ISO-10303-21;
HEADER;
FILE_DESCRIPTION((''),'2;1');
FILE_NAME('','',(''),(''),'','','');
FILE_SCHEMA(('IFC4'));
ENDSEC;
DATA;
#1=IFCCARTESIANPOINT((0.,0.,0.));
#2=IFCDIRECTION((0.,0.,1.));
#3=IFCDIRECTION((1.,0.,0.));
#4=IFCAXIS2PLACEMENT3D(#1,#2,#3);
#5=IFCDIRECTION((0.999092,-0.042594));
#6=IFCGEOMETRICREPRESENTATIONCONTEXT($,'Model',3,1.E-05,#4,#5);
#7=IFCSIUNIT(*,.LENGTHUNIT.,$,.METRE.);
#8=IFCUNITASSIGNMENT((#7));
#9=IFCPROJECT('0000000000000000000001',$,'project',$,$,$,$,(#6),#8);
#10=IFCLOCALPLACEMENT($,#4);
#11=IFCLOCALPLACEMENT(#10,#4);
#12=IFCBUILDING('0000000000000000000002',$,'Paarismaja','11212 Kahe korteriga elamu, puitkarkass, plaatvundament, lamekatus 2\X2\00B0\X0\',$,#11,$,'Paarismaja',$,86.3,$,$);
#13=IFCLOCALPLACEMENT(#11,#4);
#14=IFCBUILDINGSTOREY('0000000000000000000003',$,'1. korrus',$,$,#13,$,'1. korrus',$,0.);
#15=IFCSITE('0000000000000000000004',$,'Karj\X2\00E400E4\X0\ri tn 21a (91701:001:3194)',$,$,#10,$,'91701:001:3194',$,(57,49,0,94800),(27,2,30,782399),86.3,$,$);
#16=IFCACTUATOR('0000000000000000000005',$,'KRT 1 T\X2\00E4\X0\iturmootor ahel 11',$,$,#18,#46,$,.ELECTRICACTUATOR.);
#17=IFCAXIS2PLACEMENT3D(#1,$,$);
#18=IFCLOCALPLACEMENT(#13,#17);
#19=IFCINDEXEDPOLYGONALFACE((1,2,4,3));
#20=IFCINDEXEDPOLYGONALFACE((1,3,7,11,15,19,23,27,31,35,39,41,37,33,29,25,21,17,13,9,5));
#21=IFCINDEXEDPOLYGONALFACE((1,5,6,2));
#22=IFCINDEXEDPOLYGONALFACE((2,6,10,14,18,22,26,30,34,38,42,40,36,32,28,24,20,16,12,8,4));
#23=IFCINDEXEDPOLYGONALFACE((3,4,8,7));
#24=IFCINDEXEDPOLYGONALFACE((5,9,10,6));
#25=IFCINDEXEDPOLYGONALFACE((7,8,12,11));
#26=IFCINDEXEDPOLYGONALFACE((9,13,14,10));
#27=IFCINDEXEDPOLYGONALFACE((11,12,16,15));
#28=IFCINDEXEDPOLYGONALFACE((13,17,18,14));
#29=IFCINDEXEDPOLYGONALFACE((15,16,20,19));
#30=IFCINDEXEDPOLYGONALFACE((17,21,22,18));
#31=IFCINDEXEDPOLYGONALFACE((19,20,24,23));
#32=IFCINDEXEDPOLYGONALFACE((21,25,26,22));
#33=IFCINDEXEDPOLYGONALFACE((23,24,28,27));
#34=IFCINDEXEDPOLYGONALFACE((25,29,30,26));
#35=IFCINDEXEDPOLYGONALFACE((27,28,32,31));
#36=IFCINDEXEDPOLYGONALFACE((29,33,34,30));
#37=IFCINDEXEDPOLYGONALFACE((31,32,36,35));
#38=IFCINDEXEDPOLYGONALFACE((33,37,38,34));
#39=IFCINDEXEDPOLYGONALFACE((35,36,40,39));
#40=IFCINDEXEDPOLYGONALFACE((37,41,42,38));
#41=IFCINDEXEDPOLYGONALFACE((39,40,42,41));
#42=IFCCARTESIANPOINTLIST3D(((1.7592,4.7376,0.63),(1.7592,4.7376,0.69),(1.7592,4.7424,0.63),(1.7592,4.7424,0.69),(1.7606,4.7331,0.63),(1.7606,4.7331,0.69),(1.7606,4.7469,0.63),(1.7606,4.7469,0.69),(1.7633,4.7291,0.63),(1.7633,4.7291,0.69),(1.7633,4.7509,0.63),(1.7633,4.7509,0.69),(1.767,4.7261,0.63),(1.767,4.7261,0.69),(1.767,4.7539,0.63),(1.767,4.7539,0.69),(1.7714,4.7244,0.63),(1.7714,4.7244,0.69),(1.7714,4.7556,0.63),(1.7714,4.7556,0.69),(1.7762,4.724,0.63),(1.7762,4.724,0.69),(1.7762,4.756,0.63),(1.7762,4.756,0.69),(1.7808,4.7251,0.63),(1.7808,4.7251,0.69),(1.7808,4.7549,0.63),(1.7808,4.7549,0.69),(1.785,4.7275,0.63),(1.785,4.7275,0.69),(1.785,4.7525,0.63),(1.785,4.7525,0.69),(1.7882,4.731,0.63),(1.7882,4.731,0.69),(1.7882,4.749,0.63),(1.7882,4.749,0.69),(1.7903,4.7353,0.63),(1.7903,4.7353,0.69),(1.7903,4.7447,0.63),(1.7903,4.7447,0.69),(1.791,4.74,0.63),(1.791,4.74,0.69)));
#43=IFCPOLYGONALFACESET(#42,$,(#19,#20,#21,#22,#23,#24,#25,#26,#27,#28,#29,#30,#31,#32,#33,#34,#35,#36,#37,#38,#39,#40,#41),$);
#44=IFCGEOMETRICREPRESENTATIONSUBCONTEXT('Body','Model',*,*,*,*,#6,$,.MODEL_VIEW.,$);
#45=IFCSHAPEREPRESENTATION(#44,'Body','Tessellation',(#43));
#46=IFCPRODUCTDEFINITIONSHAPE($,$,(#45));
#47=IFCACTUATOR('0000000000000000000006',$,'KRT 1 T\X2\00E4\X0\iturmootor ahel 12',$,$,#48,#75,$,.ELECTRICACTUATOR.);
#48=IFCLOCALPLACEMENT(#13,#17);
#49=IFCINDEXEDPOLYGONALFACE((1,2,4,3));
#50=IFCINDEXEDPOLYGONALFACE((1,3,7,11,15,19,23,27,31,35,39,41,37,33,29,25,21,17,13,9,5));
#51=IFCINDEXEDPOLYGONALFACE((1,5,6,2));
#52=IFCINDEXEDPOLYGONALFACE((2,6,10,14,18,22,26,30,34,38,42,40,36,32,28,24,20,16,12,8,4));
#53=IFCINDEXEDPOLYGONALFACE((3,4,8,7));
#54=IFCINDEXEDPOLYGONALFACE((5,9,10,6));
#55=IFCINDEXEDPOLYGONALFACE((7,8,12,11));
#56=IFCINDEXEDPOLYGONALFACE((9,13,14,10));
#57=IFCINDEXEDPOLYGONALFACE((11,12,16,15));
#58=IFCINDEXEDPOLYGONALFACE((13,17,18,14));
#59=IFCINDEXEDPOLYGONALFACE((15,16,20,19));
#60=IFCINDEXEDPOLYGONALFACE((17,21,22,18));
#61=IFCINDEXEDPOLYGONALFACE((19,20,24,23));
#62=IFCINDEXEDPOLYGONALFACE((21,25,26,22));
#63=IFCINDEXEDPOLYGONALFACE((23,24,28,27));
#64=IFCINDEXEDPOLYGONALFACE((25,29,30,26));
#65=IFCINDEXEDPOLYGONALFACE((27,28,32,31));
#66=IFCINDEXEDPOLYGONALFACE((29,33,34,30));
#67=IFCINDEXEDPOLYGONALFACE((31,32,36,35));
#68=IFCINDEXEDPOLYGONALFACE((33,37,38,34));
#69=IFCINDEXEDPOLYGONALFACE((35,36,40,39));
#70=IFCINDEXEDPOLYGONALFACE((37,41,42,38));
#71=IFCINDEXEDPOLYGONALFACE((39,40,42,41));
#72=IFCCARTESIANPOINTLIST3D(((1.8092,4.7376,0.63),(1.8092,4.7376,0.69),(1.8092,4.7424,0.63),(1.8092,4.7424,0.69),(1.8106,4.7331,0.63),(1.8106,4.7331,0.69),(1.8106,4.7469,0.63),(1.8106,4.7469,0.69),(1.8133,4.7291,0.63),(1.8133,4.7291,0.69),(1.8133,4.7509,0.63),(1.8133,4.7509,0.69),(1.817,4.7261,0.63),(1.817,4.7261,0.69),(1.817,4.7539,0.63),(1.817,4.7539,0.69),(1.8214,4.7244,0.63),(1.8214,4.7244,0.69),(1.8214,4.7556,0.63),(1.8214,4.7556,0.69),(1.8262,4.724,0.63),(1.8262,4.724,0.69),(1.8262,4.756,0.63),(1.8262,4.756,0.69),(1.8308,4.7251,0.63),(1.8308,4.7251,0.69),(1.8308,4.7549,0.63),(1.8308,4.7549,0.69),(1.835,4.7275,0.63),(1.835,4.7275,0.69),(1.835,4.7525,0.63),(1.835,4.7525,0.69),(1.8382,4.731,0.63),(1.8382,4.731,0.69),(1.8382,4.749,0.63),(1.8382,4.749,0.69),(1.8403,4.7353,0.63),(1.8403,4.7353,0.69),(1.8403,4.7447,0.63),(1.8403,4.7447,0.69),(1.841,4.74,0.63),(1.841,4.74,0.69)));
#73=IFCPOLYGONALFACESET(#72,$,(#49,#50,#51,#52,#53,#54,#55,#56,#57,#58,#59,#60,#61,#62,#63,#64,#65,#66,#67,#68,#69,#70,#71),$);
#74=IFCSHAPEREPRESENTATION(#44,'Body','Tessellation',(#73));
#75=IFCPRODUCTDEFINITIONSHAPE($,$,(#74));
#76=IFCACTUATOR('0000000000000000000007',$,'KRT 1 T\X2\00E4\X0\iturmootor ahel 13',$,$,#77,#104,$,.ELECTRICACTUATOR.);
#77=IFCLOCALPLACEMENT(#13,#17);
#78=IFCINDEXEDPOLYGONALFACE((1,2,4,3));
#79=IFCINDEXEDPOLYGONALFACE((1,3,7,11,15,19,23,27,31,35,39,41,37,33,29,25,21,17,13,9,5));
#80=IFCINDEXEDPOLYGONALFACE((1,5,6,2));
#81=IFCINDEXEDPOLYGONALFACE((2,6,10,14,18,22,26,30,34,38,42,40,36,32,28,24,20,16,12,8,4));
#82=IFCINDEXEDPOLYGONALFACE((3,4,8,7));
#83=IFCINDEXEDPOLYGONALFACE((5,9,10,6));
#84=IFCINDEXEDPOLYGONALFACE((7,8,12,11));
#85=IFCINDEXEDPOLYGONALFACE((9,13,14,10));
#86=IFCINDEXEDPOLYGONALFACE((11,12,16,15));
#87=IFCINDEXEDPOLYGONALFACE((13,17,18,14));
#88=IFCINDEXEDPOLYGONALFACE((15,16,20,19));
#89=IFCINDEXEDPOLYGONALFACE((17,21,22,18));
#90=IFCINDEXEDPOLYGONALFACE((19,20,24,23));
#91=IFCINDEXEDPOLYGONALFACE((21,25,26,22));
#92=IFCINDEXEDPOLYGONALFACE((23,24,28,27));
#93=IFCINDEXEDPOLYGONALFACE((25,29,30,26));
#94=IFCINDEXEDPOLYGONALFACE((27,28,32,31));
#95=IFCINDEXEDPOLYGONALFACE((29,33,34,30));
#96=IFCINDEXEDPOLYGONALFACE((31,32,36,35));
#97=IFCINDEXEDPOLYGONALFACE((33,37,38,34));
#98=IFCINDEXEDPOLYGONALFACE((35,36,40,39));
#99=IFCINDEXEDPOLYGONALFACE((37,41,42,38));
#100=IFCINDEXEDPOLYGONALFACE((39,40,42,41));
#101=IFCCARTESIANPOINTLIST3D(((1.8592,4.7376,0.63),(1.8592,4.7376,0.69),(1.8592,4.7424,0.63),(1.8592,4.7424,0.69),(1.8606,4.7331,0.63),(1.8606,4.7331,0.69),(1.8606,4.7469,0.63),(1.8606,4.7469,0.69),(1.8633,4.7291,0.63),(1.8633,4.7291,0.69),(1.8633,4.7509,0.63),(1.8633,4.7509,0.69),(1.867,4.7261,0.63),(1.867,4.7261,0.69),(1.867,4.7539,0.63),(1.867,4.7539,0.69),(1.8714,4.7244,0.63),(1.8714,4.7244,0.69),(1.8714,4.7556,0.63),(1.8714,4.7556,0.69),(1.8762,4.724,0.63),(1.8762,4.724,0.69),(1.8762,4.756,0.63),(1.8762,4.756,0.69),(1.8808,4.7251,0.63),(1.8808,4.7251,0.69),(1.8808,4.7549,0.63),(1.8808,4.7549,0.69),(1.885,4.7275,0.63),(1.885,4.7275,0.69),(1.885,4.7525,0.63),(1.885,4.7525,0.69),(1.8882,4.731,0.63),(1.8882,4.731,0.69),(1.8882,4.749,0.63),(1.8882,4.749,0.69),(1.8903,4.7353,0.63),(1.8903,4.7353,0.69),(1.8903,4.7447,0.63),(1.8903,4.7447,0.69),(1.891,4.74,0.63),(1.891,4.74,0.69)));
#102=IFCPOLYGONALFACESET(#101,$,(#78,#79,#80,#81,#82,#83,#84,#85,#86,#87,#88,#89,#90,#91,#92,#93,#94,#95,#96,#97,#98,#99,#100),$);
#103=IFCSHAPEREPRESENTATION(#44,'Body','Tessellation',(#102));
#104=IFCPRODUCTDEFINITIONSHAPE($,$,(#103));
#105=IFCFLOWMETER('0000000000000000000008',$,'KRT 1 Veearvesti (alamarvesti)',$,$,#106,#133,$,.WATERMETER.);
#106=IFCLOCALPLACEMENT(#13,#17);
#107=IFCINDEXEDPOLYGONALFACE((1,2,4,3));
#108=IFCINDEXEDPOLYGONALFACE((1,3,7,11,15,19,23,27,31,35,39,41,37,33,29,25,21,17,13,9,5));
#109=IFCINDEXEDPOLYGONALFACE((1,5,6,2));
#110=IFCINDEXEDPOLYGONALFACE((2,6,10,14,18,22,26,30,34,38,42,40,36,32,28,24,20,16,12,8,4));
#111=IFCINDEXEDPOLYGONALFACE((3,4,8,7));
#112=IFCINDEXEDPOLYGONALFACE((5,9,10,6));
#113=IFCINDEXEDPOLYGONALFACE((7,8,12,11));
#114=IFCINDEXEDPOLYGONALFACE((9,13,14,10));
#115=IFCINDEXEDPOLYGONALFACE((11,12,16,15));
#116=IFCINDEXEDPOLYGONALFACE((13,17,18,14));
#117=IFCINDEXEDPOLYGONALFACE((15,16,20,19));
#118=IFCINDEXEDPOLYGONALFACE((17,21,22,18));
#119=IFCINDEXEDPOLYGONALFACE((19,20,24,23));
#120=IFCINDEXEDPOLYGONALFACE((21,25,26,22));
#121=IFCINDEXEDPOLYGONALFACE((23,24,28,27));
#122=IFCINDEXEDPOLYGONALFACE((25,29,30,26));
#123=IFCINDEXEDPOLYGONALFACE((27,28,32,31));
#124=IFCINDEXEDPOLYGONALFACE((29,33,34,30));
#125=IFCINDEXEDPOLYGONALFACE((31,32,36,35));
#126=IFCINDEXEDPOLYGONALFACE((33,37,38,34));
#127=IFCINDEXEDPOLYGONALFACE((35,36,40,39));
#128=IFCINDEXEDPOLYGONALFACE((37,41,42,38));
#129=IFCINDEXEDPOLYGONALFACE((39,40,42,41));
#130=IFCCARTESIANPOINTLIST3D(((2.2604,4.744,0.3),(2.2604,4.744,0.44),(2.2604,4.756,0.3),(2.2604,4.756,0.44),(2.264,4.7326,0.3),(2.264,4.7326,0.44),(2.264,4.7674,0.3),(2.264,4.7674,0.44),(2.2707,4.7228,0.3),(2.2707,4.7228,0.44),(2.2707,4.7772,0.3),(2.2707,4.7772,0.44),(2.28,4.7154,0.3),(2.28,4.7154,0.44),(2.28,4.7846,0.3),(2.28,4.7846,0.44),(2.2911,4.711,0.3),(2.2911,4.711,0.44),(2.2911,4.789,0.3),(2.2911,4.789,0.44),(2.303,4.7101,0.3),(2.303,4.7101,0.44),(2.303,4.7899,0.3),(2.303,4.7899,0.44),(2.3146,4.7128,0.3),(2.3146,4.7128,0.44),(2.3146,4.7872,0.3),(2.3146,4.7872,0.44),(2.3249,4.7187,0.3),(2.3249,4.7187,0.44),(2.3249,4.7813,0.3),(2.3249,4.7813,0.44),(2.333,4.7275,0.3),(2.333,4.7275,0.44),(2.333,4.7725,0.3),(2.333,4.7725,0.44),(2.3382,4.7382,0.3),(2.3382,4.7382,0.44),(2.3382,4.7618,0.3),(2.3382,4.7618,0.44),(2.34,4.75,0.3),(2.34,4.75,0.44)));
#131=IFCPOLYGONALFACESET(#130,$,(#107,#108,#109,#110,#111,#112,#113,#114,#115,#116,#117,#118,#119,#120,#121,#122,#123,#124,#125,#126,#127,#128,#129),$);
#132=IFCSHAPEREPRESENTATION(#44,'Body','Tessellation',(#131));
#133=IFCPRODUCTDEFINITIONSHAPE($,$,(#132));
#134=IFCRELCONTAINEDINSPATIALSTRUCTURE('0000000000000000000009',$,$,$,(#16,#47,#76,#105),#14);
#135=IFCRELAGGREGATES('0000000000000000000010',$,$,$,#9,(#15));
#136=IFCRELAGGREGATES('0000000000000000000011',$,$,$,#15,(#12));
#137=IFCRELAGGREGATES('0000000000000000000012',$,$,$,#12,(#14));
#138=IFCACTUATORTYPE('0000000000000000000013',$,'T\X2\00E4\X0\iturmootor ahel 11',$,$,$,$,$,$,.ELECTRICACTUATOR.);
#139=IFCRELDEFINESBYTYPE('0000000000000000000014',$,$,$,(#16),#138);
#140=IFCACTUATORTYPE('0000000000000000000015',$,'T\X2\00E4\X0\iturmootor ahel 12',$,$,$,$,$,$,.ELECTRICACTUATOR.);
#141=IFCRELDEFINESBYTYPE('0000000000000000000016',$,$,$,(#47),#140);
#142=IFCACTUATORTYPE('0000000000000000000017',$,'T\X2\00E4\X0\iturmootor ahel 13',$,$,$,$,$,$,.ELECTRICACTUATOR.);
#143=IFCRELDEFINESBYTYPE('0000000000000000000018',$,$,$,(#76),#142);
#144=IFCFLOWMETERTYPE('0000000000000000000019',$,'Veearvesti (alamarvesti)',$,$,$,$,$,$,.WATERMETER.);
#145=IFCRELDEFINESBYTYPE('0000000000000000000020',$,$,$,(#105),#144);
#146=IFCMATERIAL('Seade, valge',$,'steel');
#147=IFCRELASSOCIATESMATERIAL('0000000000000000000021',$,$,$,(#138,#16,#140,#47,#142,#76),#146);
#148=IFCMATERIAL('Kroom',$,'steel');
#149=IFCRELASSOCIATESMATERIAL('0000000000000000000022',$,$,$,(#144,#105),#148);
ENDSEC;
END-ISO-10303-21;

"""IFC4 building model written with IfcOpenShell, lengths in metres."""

from ifc_helpers import new_model, si_unit, direction, frame, origin_with_axes, place, context, subcontext, project, spatial, circle, extrude, material, type_object, element, save


model = new_model("IFC4")

# Units and contexts
model_context = context("Model", 3, precision=1e-05, world=origin_with_axes(), true_north=direction((0.999092, -0.042594)))
body_context = subcontext(model_context, "Body", "Model", "MODEL_VIEW")
ifc_project = project(units=[si_unit("LENGTHUNIT", "METRE")], contexts=[model_context])

# Site, building, storey
site_placement = place(None, origin_with_axes())
site = spatial("IfcSite", under=ifc_project, at=site_placement, Name="Karjääri tn 21a (91701:001:3194)", LongName="91701:001:3194", RefLatitude=(57, 49, 0, 94800), RefLongitude=(27, 2, 30, 782399), RefElevation=86.3)
building_placement = place(site_placement, origin_with_axes())
building = spatial("IfcBuilding", under=site, at=building_placement, Name="Paarismaja", Description="11212 Kahe korteriga elamu, puitkarkass, plaatvundament, lamekatus 2°", LongName="Paarismaja", ElevationOfRefHeight=86.3)
storey_placement = place(building_placement, origin_with_axes())
storey = spatial("IfcBuildingStorey", under=building, at=storey_placement, Name="1. korrus", LongName="1. korrus", Elevation=0.0)

# Actuators
ifc_material_1 = material(Name="Seade, valge", Category="steel")
actuator_type_1 = type_object("IfcActuatorType", Name="Täiturmootor ahel 11", PredefinedType="ELECTRICACTUATOR", material=ifc_material_1)
actuator_1_placement = place(storey_placement, frame((1.775, 4.74, 0.0), z_axis=(0.0, 0.0, 1.0), x_axis=(1.0, 0.0, 0.0)))
element("IfcActuator", 1, at=actuator_1_placement, inside=storey, type_object=actuator_type_1, material=ifc_material_1, Name="KRT 1 Täiturmootor ahel 11", PredefinedType="ELECTRICACTUATOR", context=body_context, shape_type="SweptSolid", body=[
    extrude(circle(Radius=0.016), frame((0.0, 0.0, 0.63), z_axis=(0.0, 0.0, 1.0), x_axis=(1.0, 0.0, 0.0)), (0.0, 0.0, 1.0), 0.06),
])
actuator_type_2 = type_object("IfcActuatorType", Name="Täiturmootor ahel 12", PredefinedType="ELECTRICACTUATOR", material=ifc_material_1)
actuator_2_placement = place(storey_placement, frame((1.825, 4.74, 0.0), z_axis=(0.0, 0.0, 1.0), x_axis=(1.0, 0.0, 0.0)))
element("IfcActuator", 2, at=actuator_2_placement, inside=storey, type_object=actuator_type_2, material=ifc_material_1, Name="KRT 1 Täiturmootor ahel 12", PredefinedType="ELECTRICACTUATOR", context=body_context, shape_type="SweptSolid", body=[
    extrude(circle(Radius=0.016), frame((0.0, 0.0, 0.63), z_axis=(0.0, 0.0, 1.0), x_axis=(1.0, 0.0, 0.0)), (0.0, 0.0, 1.0), 0.06),
])
actuator_type_3 = type_object("IfcActuatorType", Name="Täiturmootor ahel 13", PredefinedType="ELECTRICACTUATOR", material=ifc_material_1)
actuator_3_placement = place(storey_placement, frame((1.875, 4.74, 0.0), z_axis=(0.0, 0.0, 1.0), x_axis=(1.0, 0.0, 0.0)))
element("IfcActuator", 3, at=actuator_3_placement, inside=storey, type_object=actuator_type_3, material=ifc_material_1, Name="KRT 1 Täiturmootor ahel 13", PredefinedType="ELECTRICACTUATOR", context=body_context, shape_type="SweptSolid", body=[
    extrude(circle(Radius=0.016), frame((0.0, 0.0, 0.63), z_axis=(0.0, 0.0, 1.0), x_axis=(1.0, 0.0, 0.0)), (0.0, 0.0, 1.0), 0.06),
])

# Flow meter
ifc_material_2 = material(Name="Kroom", Category="steel")
flow_meter_type = type_object("IfcFlowMeterType", Name="Veearvesti (alamarvesti)", PredefinedType="WATERMETER", material=ifc_material_2)
flow_meter_placement = place(storey_placement, frame((2.3, 4.75, 0.0), z_axis=(0.0, 0.0, 1.0), x_axis=(1.0, 0.0, 0.0)))
element("IfcFlowMeter", 4, at=flow_meter_placement, inside=storey, type_object=flow_meter_type, material=ifc_material_2, Name="KRT 1 Veearvesti (alamarvesti)", PredefinedType="WATERMETER", context=body_context, shape_type="SweptSolid", body=[
    extrude(circle(Radius=0.04), frame((0.0, 0.0, 0.3), z_axis=(0.0, 0.0, 1.0), x_axis=(1.0, 0.0, 0.0)), (0.0, 0.0, 1.0), 0.14),
])

save(model, "model.ifc")
